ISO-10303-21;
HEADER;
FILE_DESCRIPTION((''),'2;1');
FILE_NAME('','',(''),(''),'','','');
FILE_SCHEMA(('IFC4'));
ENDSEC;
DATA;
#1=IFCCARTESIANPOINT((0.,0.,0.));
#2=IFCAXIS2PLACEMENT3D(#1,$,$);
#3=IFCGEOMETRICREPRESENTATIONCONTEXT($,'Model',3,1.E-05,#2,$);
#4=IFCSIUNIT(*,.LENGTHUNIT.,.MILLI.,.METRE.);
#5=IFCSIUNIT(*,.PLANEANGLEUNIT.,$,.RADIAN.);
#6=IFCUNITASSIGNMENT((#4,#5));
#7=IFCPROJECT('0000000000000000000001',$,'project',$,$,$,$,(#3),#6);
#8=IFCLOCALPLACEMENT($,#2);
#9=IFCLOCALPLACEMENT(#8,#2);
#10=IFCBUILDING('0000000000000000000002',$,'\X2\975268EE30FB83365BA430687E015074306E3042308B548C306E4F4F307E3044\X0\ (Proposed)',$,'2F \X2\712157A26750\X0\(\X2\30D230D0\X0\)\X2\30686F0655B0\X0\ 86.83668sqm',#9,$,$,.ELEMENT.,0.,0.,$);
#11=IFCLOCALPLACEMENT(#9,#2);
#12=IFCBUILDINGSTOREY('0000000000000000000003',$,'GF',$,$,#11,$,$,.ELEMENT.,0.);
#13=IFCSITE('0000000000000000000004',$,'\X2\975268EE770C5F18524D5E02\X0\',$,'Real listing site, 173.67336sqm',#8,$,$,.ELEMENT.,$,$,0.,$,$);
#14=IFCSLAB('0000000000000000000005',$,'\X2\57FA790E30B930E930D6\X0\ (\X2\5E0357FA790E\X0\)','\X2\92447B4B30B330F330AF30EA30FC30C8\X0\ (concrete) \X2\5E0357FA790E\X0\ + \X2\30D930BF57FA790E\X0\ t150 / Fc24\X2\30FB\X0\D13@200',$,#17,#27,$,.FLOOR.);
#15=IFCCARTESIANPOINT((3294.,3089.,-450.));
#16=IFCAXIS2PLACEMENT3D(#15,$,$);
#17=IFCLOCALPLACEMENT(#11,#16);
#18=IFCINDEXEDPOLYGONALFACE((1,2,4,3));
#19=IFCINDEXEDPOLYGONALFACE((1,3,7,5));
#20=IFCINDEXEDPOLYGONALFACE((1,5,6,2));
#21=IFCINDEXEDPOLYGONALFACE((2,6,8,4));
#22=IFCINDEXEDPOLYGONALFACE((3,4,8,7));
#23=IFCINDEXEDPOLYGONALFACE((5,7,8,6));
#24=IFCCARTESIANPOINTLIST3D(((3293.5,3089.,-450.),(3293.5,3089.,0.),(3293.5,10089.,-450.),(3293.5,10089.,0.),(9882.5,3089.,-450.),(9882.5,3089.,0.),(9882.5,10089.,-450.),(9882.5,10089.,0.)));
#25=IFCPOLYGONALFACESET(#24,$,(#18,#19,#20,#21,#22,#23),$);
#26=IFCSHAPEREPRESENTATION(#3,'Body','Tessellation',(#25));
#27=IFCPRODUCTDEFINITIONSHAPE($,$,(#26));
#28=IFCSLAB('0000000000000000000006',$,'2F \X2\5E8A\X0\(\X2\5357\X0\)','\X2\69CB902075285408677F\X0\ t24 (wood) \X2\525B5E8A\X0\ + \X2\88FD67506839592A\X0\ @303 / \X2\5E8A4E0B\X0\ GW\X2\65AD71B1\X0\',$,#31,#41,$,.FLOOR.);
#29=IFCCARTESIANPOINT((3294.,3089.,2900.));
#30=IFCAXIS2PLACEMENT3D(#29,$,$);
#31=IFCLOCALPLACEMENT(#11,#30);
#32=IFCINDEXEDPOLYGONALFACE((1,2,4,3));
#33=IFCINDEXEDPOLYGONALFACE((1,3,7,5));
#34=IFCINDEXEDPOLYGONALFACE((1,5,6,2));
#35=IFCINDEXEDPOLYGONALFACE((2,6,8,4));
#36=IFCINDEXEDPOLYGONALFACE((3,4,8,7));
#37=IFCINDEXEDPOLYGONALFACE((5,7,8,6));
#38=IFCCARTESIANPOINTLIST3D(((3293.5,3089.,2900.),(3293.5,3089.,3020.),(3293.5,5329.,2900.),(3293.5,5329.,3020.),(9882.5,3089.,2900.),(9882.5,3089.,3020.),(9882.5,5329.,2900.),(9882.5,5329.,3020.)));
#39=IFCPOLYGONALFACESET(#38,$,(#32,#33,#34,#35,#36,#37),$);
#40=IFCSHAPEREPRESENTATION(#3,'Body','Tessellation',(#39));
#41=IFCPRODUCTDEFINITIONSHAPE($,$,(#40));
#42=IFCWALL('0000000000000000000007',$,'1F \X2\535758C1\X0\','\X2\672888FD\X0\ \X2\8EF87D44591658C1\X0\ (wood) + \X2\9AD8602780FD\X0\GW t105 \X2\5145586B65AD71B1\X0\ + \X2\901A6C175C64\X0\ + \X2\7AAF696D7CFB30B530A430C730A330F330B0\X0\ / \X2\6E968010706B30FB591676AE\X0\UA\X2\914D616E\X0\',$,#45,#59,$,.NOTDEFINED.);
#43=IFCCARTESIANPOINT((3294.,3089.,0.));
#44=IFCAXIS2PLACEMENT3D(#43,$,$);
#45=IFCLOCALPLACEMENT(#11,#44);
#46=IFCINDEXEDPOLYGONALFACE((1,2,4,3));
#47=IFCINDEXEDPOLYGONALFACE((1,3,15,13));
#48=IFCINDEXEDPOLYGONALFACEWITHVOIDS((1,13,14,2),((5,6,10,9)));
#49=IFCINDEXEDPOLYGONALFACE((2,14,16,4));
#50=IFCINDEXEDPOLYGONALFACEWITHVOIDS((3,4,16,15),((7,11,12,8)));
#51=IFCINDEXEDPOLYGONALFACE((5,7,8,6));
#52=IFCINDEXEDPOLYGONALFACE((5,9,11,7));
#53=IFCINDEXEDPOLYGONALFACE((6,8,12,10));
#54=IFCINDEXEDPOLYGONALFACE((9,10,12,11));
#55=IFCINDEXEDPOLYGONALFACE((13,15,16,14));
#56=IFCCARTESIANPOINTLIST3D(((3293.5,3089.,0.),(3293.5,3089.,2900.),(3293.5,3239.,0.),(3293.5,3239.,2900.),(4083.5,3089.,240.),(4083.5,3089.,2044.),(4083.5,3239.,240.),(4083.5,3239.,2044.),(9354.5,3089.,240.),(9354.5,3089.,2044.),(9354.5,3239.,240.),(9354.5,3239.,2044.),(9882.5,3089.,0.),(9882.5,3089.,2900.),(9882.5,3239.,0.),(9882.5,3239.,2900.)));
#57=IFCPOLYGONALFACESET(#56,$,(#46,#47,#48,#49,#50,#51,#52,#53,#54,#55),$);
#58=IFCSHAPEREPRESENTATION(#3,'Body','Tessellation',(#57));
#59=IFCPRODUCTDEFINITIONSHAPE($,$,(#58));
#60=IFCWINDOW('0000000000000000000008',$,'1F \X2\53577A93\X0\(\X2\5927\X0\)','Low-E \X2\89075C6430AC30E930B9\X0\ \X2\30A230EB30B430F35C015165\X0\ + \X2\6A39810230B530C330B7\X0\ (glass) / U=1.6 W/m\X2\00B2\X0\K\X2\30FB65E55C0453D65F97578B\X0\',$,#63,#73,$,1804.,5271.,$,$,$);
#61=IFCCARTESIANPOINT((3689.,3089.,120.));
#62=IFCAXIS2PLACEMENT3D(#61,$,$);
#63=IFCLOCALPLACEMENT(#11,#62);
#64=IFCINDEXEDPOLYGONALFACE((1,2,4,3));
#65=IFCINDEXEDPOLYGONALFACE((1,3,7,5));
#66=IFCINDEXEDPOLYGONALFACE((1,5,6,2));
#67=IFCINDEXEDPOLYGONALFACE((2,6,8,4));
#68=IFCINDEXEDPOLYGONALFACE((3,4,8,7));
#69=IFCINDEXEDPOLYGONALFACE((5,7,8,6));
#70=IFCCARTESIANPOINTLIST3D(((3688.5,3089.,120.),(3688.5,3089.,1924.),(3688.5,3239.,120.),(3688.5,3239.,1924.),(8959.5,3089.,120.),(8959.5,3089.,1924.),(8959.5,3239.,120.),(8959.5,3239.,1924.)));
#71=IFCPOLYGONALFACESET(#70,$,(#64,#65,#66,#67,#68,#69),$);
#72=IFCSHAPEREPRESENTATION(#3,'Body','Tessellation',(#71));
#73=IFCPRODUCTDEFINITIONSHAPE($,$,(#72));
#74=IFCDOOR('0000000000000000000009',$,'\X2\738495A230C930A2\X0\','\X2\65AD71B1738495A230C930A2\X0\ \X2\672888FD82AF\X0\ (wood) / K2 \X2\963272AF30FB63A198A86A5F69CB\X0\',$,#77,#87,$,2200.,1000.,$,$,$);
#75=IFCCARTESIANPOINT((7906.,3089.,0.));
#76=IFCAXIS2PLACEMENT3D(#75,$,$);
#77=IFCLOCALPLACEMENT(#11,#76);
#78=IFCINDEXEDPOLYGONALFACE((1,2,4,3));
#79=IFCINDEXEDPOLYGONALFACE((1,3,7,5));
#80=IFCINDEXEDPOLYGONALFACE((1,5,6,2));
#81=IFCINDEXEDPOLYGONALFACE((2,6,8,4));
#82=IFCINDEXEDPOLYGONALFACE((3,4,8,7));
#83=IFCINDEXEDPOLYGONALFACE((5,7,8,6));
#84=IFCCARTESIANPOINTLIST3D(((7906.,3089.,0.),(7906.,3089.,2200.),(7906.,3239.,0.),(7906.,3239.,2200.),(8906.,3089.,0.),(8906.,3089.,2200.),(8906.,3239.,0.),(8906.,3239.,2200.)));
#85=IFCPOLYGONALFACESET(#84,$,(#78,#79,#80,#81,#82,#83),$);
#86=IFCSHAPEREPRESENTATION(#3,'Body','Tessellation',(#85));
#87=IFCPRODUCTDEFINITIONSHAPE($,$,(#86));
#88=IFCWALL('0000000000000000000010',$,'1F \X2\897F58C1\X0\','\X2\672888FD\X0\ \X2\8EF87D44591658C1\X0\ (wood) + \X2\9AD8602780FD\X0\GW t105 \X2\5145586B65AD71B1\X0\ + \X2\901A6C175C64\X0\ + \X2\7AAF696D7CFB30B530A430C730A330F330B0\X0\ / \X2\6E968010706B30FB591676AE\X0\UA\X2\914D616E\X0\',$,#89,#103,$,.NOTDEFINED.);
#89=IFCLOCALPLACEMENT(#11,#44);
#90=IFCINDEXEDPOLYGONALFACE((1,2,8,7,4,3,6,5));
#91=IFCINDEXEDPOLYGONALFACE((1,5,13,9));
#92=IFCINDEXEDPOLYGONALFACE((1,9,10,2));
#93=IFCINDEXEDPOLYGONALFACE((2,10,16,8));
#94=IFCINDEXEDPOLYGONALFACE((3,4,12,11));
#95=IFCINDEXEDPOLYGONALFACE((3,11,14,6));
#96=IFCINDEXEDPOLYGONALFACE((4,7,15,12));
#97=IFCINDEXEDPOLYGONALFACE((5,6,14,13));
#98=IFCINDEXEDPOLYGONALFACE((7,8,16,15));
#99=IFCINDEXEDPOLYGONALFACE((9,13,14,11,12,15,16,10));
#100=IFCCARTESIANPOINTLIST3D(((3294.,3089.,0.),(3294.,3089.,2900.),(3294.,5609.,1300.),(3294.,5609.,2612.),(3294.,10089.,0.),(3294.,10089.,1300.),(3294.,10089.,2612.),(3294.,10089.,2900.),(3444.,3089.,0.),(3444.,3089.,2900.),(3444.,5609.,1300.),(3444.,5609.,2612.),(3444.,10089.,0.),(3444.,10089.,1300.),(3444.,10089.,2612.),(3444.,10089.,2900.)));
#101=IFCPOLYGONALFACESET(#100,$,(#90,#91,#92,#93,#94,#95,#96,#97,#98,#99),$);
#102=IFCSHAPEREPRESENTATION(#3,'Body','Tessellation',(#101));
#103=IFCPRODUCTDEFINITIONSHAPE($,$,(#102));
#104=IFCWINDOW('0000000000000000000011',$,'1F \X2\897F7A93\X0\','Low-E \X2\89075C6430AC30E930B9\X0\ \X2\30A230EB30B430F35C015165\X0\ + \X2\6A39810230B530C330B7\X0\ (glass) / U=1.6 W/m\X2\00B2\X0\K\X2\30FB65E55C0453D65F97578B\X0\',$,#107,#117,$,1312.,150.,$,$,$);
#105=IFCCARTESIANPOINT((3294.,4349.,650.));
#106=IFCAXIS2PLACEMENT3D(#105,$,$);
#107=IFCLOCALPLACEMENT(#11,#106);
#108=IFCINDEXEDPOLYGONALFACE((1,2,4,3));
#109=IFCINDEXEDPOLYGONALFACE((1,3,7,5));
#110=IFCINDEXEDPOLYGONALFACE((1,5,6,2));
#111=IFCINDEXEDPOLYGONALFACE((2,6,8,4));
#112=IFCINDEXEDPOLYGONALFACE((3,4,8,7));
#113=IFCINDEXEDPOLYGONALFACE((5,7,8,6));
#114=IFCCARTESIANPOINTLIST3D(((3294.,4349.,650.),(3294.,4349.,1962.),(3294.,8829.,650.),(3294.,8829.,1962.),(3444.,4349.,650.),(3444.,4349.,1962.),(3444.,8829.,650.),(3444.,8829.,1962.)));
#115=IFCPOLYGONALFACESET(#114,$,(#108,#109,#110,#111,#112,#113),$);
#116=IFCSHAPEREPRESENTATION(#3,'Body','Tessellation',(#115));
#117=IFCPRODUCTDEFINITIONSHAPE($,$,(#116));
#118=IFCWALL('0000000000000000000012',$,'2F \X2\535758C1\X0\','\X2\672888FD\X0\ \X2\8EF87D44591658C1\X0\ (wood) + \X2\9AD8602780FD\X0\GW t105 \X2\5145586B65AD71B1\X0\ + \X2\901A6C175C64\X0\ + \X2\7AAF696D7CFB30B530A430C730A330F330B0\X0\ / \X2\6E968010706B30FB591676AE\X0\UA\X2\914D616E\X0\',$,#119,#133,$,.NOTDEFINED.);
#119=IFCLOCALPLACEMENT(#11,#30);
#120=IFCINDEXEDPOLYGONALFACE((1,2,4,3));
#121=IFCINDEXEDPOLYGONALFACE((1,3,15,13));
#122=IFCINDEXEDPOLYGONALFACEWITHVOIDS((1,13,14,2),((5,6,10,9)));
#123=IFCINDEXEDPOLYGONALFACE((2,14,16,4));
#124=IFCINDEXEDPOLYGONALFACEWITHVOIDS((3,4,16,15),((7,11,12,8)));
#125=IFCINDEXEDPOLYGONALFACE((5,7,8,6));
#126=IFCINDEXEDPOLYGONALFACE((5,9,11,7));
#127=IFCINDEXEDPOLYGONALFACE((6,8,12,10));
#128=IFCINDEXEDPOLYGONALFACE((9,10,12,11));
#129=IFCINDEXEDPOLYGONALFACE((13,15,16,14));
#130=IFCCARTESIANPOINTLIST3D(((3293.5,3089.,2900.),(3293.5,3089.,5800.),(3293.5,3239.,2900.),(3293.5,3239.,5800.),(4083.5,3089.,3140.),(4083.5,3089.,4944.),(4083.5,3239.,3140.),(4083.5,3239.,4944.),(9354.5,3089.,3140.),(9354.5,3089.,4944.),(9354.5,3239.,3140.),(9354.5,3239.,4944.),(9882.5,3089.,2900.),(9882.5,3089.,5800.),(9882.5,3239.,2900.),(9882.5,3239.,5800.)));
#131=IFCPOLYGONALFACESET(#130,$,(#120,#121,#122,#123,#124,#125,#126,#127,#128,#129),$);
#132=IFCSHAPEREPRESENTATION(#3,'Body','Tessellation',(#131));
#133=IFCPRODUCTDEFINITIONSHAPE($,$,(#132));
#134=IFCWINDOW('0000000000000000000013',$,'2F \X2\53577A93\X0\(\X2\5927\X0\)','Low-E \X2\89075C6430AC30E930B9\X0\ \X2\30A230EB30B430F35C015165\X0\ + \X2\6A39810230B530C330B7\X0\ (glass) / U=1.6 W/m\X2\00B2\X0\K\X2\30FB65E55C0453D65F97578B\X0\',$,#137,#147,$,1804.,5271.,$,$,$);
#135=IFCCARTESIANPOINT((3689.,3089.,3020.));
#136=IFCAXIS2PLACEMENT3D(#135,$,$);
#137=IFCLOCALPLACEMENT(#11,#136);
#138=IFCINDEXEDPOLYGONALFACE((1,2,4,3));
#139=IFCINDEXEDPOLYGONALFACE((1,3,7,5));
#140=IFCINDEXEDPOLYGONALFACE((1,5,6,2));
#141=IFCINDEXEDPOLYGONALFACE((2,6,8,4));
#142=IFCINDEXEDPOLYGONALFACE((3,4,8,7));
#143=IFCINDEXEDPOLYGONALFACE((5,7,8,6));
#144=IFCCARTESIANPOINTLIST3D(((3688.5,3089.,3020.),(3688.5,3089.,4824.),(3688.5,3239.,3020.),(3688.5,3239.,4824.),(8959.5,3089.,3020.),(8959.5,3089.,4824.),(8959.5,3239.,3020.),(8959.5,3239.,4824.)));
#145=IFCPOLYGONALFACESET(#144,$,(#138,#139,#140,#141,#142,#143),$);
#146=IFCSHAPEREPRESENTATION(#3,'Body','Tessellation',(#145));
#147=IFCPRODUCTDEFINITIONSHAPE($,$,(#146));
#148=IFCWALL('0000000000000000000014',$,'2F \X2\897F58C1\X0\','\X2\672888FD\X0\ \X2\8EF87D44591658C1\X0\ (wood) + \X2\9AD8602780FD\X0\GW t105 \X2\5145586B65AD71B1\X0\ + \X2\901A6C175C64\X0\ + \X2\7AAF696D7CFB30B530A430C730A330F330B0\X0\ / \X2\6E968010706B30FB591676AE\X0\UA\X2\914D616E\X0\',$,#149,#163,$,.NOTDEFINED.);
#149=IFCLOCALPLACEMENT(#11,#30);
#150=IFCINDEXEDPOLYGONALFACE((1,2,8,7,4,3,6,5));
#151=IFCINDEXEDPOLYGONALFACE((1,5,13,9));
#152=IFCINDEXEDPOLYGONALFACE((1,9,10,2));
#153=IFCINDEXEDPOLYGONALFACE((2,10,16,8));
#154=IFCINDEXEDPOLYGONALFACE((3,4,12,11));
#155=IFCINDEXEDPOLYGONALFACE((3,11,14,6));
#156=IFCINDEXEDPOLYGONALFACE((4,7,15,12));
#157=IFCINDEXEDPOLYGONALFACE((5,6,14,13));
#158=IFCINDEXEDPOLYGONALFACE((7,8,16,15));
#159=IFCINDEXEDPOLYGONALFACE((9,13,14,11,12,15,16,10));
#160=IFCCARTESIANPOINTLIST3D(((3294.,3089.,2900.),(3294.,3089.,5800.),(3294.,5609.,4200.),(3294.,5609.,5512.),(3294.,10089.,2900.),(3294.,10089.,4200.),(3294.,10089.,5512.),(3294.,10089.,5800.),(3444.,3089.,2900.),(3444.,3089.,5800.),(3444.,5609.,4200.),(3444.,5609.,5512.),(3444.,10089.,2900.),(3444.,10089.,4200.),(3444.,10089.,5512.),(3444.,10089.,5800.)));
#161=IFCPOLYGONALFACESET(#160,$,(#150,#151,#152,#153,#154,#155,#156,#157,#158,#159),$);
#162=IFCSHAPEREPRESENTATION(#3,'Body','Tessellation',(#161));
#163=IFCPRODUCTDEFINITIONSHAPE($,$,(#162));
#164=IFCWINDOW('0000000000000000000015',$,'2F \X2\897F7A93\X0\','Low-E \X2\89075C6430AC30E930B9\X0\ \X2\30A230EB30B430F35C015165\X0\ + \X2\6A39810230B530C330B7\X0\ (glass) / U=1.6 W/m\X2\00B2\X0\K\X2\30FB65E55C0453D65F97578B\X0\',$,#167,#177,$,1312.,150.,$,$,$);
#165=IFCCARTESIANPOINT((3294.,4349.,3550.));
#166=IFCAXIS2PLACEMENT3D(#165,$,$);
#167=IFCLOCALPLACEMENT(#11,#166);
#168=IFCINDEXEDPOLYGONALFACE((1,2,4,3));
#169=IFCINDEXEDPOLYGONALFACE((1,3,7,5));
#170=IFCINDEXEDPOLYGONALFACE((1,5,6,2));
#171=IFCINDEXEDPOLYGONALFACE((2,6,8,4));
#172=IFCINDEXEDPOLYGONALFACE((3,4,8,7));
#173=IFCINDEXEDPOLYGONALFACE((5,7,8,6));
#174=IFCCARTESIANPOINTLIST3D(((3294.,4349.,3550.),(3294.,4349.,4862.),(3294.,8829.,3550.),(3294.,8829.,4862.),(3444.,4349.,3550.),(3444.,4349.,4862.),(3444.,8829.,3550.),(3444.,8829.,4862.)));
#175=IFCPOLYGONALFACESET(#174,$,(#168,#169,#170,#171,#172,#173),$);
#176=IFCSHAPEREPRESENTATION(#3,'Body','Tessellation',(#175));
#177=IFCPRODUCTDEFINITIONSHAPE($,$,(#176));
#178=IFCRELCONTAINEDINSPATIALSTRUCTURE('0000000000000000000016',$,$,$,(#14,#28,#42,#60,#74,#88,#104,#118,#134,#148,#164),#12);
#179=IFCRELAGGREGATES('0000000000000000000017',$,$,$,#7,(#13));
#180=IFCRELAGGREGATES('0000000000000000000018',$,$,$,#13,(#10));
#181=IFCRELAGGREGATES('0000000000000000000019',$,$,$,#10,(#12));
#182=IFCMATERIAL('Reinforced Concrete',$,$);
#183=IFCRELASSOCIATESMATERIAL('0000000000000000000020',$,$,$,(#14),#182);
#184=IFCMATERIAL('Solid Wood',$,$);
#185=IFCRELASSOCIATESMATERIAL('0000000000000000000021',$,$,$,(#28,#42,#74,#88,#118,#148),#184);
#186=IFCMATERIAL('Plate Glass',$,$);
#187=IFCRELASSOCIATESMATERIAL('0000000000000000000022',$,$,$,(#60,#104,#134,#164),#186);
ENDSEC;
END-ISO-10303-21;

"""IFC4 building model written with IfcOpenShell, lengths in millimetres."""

from ifc_helpers import new_model, si_unit, frame, frame_2d, origin, place, context, project, spatial, rectangle, extrude, material, element, fill, save


model = new_model("IFC4")

# Units and contexts
model_context = context("Model", 3, precision=1e-05, world=origin())
ifc_project = project(units=[si_unit("LENGTHUNIT", "METRE", prefix="MILLI"), si_unit("PLANEANGLEUNIT", "RADIAN")], contexts=[model_context])

# Site, building, storey
site_placement = place(None, origin())
site = spatial("IfcSite", under=ifc_project, at=site_placement, Name="青森県弘前市", ObjectType="Real listing site, 173.67336sqm", CompositionType="ELEMENT", RefElevation=0.0)
building_placement = place(site_placement, origin())
building = spatial("IfcBuilding", under=site, at=building_placement, Name="青森・茶室と縁側のある和の住まい (Proposed)", ObjectType="2F 無垢材(ヒバ)と漆喰 86.83668sqm", CompositionType="ELEMENT", ElevationOfRefHeight=0.0, ElevationOfTerrain=0.0)
storey_placement = place(building_placement, origin())
storey = spatial("IfcBuildingStorey", under=building, at=storey_placement, Name="GF", CompositionType="ELEMENT", Elevation=0.0)

# Slabs
ifc_material_1 = material(Name="Reinforced Concrete")
slab_1_placement = place(storey_placement, frame((3294.0, 3089.0, -450.0)))
element("IfcSlab", 1, at=slab_1_placement, inside=storey, material=ifc_material_1, Name="基礎スラブ (布基礎)", Description="鉄筋コンクリート (concrete) 布基礎 + ベタ基礎 t150 / Fc24・D13@200", PredefinedType="FLOOR", context=model_context, shape_type="SweptSolid", body=[
    extrude(rectangle(XDim=6589.0, YDim=7000.0, at=frame_2d((3294.0, 3500.0))), frame((3294.0, 3089.0, -450.0)), (0.0, 0.0, 1.0), 450.0),
])
ifc_material_2 = material(Name="Solid Wood")
slab_2_placement = place(storey_placement, frame((3294.0, 3089.0, 2900.0)))
element("IfcSlab", 2, at=slab_2_placement, inside=storey, material=ifc_material_2, Name="2F 床(南)", Description="構造用合板 t24 (wood) 剛床 + 製材根太 @303 / 床下 GW断熱", PredefinedType="FLOOR", context=model_context, shape_type="SweptSolid", body=[
    extrude(rectangle(XDim=6589.0, YDim=2240.0, at=frame_2d((3294.0, 1120.0))), frame((3294.0, 3089.0, 2900.0)), (0.0, 0.0, 1.0), 120.0),
])

# Wall, openings, window, door
wall_1_placement = place(storey_placement, frame((3294.0, 3089.0, 0.0)))
wall_1 = element("IfcWall", 3, at=wall_1_placement, inside=storey, material=ifc_material_2, Name="1F 南壁", Description="木製 軸組外壁 (wood) + 高性能GW t105 充填断熱 + 通気層 + 窯業系サイディング / 準耐火・外皮UA配慮", PredefinedType="NOTDEFINED", context=model_context, shape_type="SweptSolid", body=[
    extrude(rectangle(XDim=6589.0, YDim=150.0, at=frame_2d((3294.0, 75.0))), frame((3294.0, 3089.0, 0.0)), (0.0, 0.0, 1.0), 2900.0),
])
opening_1_placement = place(storey_placement, frame((3689.0, 3089.0, 120.0)))
opening_1 = element("IfcOpeningElement", 4, at=opening_1_placement, cuts=wall_1, PredefinedType="NOTDEFINED", context=model_context, shape_type="SweptSolid", body=[
    extrude(rectangle(XDim=5271.0, YDim=150.0, at=frame_2d((2635.0, 75.0))), frame((3689.0, 3089.0, 120.0)), (0.0, 0.0, 1.0), 1804.0),
])
opening_2_placement = place(storey_placement, frame((7906.0, 3089.0, 0.0)))
opening_2 = element("IfcOpeningElement", 5, at=opening_2_placement, cuts=wall_1, PredefinedType="NOTDEFINED", context=model_context, shape_type="SweptSolid", body=[
    extrude(rectangle(XDim=1000.0, YDim=150.0, at=frame_2d((500.0, 75.0))), frame((7906.0, 3089.0, 0.0)), (0.0, 0.0, 1.0), 2200.0),
])
ifc_material_3 = material(Name="Plate Glass")
window_1_placement = place(storey_placement, frame((3689.0, 3089.0, 120.0)))
window_1 = element("IfcWindow", 6, at=window_1_placement, inside=storey, material=ifc_material_3, Name="1F 南窓(大)", Description="Low-E 複層ガラス アルゴン封入 + 樹脂サッシ (glass) / U=1.6 W/m²K・日射取得型", OverallHeight=1804.0, OverallWidth=5271.0, context=model_context, shape_type="SweptSolid", body=[
    extrude(rectangle(XDim=5271.0, YDim=150.0, at=frame_2d((2635.0, 75.0))), frame((3689.0, 3089.0, 120.0)), (0.0, 0.0, 1.0), 1804.0),
])
fill(opening_1, window_1)
door_placement = place(storey_placement, frame((7906.0, 3089.0, 0.0)))
door = element("IfcDoor", 7, at=door_placement, inside=storey, material=ifc_material_2, Name="玄関ドア", Description="断熱玄関ドア 木製芯 (wood) / K2 防犯・採風機構", OverallHeight=2200.0, OverallWidth=1000.0, context=model_context, shape_type="SweptSolid", body=[
    extrude(rectangle(XDim=1000.0, YDim=150.0, at=frame_2d((500.0, 75.0))), frame((7906.0, 3089.0, 0.0)), (0.0, 0.0, 1.0), 2200.0),
])
fill(opening_2, door)

# Walls, openings, windows
wall_2_placement = place(storey_placement, frame((3294.0, 3089.0, 0.0)))
wall_2 = element("IfcWall", 8, at=wall_2_placement, inside=storey, material=ifc_material_2, Name="1F 西壁", Description="木製 軸組外壁 (wood) + 高性能GW t105 充填断熱 + 通気層 + 窯業系サイディング / 準耐火・外皮UA配慮", PredefinedType="NOTDEFINED", context=model_context, shape_type="SweptSolid", body=[
    extrude(rectangle(XDim=150.0, YDim=7000.0, at=frame_2d((75.0, 3500.0))), frame((3294.0, 3089.0, 0.0)), (0.0, 0.0, 1.0), 2900.0),
])
opening_3_placement = place(storey_placement, frame((3294.0, 4349.0, 650.0)))
opening_3 = element("IfcOpeningElement", 9, at=opening_3_placement, cuts=wall_2, PredefinedType="NOTDEFINED", context=model_context, shape_type="SweptSolid", body=[
    extrude(rectangle(XDim=150.0, YDim=4480.0, at=frame_2d((75.0, 2240.0))), frame((3294.0, 4349.0, 650.0)), (0.0, 0.0, 1.0), 1312.0),
])
window_2_placement = place(storey_placement, frame((3294.0, 4349.0, 650.0)))
window_2 = element("IfcWindow", 10, at=window_2_placement, inside=storey, material=ifc_material_3, Name="1F 西窓", Description="Low-E 複層ガラス アルゴン封入 + 樹脂サッシ (glass) / U=1.6 W/m²K・日射取得型", OverallHeight=1312.0, OverallWidth=150.0, context=model_context, shape_type="SweptSolid", body=[
    extrude(rectangle(XDim=150.0, YDim=4480.0, at=frame_2d((75.0, 2240.0))), frame((3294.0, 4349.0, 650.0)), (0.0, 0.0, 1.0), 1312.0),
])
fill(opening_3, window_2)
wall_3_placement = place(storey_placement, frame((3294.0, 3089.0, 2900.0)))
wall_3 = element("IfcWall", 11, at=wall_3_placement, inside=storey, material=ifc_material_2, Name="2F 南壁", Description="木製 軸組外壁 (wood) + 高性能GW t105 充填断熱 + 通気層 + 窯業系サイディング / 準耐火・外皮UA配慮", PredefinedType="NOTDEFINED", context=model_context, shape_type="SweptSolid", body=[
    extrude(rectangle(XDim=6589.0, YDim=150.0, at=frame_2d((3294.0, 75.0))), frame((3294.0, 3089.0, 2900.0)), (0.0, 0.0, 1.0), 2900.0),
])
opening_4_placement = place(storey_placement, frame((3689.0, 3089.0, 3020.0)))
opening_4 = element("IfcOpeningElement", 12, at=opening_4_placement, cuts=wall_3, PredefinedType="NOTDEFINED", context=model_context, shape_type="SweptSolid", body=[
    extrude(rectangle(XDim=5271.0, YDim=150.0, at=frame_2d((2635.0, 75.0))), frame((3689.0, 3089.0, 3020.0)), (0.0, 0.0, 1.0), 1804.0),
])
window_3_placement = place(storey_placement, frame((3689.0, 3089.0, 3020.0)))
window_3 = element("IfcWindow", 13, at=window_3_placement, inside=storey, material=ifc_material_3, Name="2F 南窓(大)", Description="Low-E 複層ガラス アルゴン封入 + 樹脂サッシ (glass) / U=1.6 W/m²K・日射取得型", OverallHeight=1804.0, OverallWidth=5271.0, context=model_context, shape_type="SweptSolid", body=[
    extrude(rectangle(XDim=5271.0, YDim=150.0, at=frame_2d((2635.0, 75.0))), frame((3689.0, 3089.0, 3020.0)), (0.0, 0.0, 1.0), 1804.0),
])
fill(opening_4, window_3)
wall_4_placement = place(storey_placement, frame((3294.0, 3089.0, 2900.0)))
wall_4 = element("IfcWall", 14, at=wall_4_placement, inside=storey, material=ifc_material_2, Name="2F 西壁", Description="木製 軸組外壁 (wood) + 高性能GW t105 充填断熱 + 通気層 + 窯業系サイディング / 準耐火・外皮UA配慮", PredefinedType="NOTDEFINED", context=model_context, shape_type="SweptSolid", body=[
    extrude(rectangle(XDim=150.0, YDim=7000.0, at=frame_2d((75.0, 3500.0))), frame((3294.0, 3089.0, 2900.0)), (0.0, 0.0, 1.0), 2900.0),
])
opening_5_placement = place(storey_placement, frame((3294.0, 4349.0, 3550.0)))
opening_5 = element("IfcOpeningElement", 15, at=opening_5_placement, cuts=wall_4, PredefinedType="NOTDEFINED", context=model_context, shape_type="SweptSolid", body=[
    extrude(rectangle(XDim=150.0, YDim=4480.0, at=frame_2d((75.0, 2240.0))), frame((3294.0, 4349.0, 3550.0)), (0.0, 0.0, 1.0), 1312.0),
])
window_4_placement = place(storey_placement, frame((3294.0, 4349.0, 3550.0)))
window_4 = element("IfcWindow", 16, at=window_4_placement, inside=storey, material=ifc_material_3, Name="2F 西窓", Description="Low-E 複層ガラス アルゴン封入 + 樹脂サッシ (glass) / U=1.6 W/m²K・日射取得型", OverallHeight=1312.0, OverallWidth=150.0, context=model_context, shape_type="SweptSolid", body=[
    extrude(rectangle(XDim=150.0, YDim=4480.0, at=frame_2d((75.0, 2240.0))), frame((3294.0, 4349.0, 3550.0)), (0.0, 0.0, 1.0), 1312.0),
])
fill(opening_5, window_4)

save(model, "model.ifc")
